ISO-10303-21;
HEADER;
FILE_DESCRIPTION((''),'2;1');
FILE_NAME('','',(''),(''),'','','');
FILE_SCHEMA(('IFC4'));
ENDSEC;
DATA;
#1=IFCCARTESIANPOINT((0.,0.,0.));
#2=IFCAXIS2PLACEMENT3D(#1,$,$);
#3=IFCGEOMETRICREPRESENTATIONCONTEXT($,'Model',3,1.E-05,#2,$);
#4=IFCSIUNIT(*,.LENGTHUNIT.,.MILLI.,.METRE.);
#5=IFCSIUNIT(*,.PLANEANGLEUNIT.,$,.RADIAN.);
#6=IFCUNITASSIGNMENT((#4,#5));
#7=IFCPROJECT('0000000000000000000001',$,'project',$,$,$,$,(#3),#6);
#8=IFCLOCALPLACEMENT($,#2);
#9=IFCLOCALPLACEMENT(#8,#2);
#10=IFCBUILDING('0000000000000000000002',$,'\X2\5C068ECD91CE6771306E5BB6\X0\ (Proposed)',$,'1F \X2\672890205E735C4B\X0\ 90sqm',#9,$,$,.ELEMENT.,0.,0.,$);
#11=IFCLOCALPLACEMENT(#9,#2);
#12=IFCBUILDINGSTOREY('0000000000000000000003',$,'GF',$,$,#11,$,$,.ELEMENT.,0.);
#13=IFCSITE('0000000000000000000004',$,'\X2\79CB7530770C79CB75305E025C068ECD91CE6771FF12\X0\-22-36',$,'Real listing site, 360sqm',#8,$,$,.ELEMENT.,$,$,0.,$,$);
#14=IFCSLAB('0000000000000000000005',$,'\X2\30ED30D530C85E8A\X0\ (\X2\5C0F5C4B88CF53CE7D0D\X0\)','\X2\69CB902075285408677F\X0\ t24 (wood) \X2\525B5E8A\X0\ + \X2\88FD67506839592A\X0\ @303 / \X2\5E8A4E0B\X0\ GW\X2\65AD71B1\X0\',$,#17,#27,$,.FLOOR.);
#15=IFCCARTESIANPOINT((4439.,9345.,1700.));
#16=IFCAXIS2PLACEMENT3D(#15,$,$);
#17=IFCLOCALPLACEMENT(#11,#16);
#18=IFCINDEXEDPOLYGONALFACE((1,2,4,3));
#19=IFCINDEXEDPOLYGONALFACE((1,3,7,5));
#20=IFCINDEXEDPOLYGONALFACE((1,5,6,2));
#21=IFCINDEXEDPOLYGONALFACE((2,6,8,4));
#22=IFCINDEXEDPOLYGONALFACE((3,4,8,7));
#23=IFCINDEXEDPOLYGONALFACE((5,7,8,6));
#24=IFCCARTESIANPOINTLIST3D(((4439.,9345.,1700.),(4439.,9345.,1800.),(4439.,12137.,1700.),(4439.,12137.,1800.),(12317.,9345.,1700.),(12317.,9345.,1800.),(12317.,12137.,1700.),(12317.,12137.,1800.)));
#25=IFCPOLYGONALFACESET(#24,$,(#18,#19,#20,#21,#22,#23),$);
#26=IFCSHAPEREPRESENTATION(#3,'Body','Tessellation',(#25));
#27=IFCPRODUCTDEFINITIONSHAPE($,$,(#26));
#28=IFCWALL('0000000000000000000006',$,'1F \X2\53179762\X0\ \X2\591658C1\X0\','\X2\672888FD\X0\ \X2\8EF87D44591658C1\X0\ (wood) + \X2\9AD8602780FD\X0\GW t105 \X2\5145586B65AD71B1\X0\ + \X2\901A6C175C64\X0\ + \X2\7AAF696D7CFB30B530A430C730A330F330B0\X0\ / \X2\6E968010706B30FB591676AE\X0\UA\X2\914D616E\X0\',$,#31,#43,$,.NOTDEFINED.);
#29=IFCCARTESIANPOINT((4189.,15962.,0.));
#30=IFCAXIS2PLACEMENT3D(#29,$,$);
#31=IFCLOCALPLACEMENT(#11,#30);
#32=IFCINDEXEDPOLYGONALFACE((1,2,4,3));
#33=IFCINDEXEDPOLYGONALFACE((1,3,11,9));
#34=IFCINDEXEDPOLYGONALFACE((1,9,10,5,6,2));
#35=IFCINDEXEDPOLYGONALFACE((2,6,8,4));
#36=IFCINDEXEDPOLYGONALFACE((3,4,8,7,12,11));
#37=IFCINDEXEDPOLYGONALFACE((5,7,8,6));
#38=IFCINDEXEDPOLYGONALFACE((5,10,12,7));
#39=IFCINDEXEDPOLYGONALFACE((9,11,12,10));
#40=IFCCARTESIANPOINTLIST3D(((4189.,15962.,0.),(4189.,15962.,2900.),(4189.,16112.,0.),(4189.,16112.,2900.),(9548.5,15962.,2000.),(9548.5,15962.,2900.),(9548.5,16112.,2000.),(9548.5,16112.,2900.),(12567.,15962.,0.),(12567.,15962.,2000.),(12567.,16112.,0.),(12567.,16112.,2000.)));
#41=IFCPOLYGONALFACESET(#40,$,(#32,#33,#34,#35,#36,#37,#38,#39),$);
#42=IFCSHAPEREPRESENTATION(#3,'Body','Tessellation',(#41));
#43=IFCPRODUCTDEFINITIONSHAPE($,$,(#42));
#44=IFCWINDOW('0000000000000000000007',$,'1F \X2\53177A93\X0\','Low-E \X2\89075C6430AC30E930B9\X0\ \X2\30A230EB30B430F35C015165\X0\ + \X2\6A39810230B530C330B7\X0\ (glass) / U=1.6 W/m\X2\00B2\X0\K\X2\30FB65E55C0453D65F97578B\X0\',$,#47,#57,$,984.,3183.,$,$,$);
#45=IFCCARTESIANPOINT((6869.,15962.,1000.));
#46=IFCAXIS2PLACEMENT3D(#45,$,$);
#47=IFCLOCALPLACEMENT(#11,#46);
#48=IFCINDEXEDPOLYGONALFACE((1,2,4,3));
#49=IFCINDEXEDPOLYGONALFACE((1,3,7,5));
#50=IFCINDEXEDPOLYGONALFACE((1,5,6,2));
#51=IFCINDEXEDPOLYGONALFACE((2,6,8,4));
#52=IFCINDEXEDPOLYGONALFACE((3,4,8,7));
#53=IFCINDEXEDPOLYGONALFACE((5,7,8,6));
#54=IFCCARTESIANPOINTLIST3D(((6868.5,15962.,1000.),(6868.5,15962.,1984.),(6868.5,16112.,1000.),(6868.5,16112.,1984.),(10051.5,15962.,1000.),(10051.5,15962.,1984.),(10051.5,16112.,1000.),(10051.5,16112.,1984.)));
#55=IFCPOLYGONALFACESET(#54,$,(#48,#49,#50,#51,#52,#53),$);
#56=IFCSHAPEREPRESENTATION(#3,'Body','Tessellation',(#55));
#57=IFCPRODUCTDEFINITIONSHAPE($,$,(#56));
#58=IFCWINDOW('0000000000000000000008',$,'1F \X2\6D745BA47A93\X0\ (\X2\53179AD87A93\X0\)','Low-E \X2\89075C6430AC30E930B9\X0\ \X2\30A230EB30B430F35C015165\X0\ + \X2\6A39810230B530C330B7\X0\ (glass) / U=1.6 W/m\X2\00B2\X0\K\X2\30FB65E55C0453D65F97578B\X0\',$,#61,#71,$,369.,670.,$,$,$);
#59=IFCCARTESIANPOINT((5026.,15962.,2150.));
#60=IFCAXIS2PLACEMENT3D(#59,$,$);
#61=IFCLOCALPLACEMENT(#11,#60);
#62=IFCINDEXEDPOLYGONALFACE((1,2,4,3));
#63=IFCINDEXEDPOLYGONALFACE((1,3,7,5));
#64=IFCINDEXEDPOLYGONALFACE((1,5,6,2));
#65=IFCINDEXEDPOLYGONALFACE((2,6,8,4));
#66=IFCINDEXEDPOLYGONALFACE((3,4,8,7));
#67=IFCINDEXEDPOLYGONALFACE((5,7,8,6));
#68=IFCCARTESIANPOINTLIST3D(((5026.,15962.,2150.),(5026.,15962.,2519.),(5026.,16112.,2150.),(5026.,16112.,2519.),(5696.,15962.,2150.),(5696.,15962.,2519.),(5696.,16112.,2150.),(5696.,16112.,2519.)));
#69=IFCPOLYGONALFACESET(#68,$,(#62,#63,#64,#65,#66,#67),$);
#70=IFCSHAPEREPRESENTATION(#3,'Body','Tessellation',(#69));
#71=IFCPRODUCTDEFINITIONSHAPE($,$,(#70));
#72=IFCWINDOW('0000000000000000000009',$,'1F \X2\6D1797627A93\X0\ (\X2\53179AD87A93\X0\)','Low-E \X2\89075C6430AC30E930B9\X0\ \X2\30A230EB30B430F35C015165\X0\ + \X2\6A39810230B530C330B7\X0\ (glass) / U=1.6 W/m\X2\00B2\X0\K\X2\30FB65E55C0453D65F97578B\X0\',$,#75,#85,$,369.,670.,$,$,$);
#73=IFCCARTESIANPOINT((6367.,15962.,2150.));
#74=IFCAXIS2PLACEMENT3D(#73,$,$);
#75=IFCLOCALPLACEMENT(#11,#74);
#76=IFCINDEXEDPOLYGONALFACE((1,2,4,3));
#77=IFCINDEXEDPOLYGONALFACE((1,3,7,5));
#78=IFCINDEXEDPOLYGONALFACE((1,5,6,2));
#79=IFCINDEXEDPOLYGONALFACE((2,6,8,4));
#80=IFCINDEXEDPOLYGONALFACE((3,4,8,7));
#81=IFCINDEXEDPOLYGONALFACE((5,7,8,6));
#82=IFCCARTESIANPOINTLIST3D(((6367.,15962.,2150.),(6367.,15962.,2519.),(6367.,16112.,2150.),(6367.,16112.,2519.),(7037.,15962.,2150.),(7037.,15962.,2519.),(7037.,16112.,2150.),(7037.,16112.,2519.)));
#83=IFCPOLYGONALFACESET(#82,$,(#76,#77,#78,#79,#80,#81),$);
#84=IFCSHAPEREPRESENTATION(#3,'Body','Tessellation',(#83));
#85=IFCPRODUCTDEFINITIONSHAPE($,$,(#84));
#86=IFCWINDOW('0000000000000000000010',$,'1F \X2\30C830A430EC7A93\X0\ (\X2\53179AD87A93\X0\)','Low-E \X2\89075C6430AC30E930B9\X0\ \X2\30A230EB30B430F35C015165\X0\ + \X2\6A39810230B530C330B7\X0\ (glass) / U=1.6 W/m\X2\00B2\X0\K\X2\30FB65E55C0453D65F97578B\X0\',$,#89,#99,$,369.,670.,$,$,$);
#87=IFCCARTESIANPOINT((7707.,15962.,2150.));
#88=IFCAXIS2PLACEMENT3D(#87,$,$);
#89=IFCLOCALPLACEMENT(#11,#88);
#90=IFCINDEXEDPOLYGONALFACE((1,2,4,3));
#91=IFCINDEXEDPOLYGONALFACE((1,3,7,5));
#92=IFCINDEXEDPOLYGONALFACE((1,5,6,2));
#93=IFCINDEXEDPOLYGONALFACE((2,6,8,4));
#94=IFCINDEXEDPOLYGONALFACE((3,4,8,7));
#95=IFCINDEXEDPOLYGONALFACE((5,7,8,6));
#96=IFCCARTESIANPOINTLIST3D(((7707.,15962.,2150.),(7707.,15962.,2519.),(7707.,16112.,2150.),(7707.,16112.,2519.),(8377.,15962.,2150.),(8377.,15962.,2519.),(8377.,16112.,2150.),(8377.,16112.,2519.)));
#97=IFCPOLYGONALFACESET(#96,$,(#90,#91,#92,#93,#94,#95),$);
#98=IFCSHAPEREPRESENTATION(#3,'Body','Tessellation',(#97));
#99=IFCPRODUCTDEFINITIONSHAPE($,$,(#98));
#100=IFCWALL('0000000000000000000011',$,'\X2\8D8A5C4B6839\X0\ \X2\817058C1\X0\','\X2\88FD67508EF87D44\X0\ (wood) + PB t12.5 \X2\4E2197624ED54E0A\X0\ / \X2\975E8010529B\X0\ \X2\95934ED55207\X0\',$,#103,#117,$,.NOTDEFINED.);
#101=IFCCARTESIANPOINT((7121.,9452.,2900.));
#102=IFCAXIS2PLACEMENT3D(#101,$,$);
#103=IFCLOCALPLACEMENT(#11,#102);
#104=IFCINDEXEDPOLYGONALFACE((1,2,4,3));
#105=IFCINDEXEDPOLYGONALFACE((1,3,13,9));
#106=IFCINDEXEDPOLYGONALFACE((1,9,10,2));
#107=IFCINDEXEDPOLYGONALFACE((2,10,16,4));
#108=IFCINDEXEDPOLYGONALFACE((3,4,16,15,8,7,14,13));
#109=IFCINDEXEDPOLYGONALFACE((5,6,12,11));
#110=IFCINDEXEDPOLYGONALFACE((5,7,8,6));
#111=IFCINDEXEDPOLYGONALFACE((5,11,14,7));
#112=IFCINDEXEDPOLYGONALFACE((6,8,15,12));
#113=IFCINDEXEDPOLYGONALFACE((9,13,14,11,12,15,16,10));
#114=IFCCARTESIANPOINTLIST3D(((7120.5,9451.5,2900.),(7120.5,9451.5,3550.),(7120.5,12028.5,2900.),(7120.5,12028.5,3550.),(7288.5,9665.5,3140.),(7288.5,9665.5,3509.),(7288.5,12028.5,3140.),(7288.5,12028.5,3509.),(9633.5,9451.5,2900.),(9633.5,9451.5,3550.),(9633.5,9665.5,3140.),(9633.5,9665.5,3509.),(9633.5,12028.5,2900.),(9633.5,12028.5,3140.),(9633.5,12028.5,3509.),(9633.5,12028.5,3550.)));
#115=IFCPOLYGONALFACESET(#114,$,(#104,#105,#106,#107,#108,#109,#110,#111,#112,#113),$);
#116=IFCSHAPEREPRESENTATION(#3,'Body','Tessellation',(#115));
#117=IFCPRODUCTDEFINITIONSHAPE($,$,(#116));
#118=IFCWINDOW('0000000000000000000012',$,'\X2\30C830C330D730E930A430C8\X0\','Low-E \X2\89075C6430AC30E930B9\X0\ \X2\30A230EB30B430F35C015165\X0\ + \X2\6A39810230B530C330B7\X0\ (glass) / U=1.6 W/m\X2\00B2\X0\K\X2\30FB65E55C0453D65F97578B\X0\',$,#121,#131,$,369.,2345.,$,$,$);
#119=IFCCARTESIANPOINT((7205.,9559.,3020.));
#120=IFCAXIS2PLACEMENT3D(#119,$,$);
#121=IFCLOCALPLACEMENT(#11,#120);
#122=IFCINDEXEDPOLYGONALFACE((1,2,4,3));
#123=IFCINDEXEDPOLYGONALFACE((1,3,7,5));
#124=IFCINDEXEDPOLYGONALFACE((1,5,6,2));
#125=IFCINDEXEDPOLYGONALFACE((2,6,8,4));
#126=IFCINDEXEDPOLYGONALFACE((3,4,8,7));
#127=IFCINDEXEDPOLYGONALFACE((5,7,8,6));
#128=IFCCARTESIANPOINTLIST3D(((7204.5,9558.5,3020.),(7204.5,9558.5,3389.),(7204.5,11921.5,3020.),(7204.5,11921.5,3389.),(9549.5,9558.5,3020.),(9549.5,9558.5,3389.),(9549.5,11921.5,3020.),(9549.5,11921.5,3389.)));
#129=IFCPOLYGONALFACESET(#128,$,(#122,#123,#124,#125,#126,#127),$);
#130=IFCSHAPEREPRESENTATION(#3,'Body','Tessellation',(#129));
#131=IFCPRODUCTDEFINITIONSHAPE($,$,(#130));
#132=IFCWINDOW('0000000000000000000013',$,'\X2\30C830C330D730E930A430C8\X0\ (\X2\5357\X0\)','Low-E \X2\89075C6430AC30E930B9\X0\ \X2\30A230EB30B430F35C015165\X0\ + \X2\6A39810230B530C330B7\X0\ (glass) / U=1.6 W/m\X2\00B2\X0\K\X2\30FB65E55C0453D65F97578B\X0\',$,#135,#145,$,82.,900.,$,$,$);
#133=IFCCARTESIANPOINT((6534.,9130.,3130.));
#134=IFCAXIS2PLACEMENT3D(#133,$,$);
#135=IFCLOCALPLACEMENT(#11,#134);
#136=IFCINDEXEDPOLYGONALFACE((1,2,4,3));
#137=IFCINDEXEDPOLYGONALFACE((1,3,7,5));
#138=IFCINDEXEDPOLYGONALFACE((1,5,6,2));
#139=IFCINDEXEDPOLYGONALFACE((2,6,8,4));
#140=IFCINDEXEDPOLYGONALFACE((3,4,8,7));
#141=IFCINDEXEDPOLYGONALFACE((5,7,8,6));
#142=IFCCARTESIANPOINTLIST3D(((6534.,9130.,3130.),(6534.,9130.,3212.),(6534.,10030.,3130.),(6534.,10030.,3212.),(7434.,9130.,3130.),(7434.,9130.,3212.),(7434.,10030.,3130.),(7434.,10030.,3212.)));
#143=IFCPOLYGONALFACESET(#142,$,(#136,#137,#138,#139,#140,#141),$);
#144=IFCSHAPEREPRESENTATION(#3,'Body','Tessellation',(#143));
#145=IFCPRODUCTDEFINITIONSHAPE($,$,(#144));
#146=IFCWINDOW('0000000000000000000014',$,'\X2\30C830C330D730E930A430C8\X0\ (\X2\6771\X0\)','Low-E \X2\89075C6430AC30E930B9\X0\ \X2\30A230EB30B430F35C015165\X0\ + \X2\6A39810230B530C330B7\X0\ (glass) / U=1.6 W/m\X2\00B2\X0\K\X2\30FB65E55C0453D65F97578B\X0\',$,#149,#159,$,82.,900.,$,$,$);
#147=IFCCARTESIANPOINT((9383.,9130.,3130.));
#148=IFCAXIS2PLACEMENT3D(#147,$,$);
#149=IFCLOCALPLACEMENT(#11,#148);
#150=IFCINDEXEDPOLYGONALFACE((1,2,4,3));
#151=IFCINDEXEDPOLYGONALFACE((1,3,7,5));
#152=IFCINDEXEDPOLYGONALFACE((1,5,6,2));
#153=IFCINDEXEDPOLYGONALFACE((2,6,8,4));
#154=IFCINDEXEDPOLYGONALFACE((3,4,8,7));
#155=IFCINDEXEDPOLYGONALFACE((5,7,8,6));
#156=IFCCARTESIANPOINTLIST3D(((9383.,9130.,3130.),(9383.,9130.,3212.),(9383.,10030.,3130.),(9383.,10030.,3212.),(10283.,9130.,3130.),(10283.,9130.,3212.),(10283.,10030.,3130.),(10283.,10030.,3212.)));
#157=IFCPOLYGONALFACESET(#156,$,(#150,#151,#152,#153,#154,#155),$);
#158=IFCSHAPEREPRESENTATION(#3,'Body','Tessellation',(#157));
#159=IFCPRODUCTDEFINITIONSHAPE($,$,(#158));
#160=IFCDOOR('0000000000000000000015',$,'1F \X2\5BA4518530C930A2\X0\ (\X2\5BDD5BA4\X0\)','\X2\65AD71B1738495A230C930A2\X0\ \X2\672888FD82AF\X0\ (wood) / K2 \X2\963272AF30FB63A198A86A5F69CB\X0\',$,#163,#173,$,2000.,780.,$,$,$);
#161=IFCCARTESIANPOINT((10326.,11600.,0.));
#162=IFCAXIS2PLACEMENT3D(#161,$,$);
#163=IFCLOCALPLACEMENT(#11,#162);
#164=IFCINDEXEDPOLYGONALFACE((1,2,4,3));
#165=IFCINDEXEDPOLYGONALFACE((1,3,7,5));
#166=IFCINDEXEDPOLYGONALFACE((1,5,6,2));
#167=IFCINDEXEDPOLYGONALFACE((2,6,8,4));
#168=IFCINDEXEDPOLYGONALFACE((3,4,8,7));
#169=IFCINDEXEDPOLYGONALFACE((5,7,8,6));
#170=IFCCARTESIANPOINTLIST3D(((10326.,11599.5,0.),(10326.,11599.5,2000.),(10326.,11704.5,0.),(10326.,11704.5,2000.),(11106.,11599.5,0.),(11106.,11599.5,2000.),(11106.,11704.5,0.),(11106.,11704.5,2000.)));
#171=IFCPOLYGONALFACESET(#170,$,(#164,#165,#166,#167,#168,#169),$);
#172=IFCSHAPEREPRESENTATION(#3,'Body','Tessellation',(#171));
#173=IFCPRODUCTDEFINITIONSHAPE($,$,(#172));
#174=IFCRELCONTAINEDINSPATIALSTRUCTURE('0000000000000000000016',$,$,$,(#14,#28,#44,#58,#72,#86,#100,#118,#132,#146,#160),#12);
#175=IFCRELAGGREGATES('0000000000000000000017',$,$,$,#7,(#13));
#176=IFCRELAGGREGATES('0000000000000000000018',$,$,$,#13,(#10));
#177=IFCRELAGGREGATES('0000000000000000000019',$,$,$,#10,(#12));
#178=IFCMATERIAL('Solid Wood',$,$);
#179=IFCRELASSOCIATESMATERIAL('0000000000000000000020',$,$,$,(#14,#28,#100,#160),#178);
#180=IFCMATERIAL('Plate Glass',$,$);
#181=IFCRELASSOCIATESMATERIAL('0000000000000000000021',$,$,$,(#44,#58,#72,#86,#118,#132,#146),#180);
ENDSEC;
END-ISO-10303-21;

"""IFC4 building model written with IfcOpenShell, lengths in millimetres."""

from ifc_helpers import new_model, si_unit, frame, frame_2d, origin, place, context, project, spatial, rectangle, extrude, material, element, fill, save


model = new_model("IFC4")

# Units and contexts
model_context = context("Model", 3, precision=1e-05, world=origin())
ifc_project = project(units=[si_unit("LENGTHUNIT", "METRE", prefix="MILLI"), si_unit("PLANEANGLEUNIT", "RADIAN")], contexts=[model_context])

# Site, building, storey
site_placement = place(None, origin())
site = spatial("IfcSite", under=ifc_project, at=site_placement, Name="秋田県秋田市将軍野東２-22-36", ObjectType="Real listing site, 360sqm", CompositionType="ELEMENT", RefElevation=0.0)
building_placement = place(site_placement, origin())
building = spatial("IfcBuilding", under=site, at=building_placement, Name="将軍野東の家 (Proposed)", ObjectType="1F 木造平屋 90sqm", CompositionType="ELEMENT", ElevationOfRefHeight=0.0, ElevationOfTerrain=0.0)
storey_placement = place(building_placement, origin())
storey = spatial("IfcBuildingStorey", under=building, at=storey_placement, Name="GF", CompositionType="ELEMENT", Elevation=0.0)

# Slab
ifc_material_1 = material(Name="Solid Wood")
slab_placement = place(storey_placement, frame((4439.0, 9345.0, 1700.0)))
element("IfcSlab", 1, at=slab_placement, inside=storey, material=ifc_material_1, Name="ロフト床 (小屋裏収納)", Description="構造用合板 t24 (wood) 剛床 + 製材根太 @303 / 床下 GW断熱", PredefinedType="FLOOR", context=model_context, shape_type="SweptSolid", body=[
    extrude(rectangle(XDim=7878.0, YDim=2792.0, at=frame_2d((3939.0, 1396.0))), frame((4439.0, 9345.0, 1700.0)), (0.0, 0.0, 1.0), 100.0),
])

# Wall, openings, windows
wall_1_placement = place(storey_placement, frame((4189.0, 15962.0, 0.0)))
wall_1 = element("IfcWall", 2, at=wall_1_placement, inside=storey, material=ifc_material_1, Name="1F 北面 外壁", Description="木製 軸組外壁 (wood) + 高性能GW t105 充填断熱 + 通気層 + 窯業系サイディング / 準耐火・外皮UA配慮", PredefinedType="NOTDEFINED", context=model_context, shape_type="SweptSolid", body=[
    extrude(rectangle(XDim=8378.0, YDim=150.0, at=frame_2d((4189.0, 75.0))), frame((4189.0, 15962.0, 0.0)), (0.0, 0.0, 1.0), 2900.0),
])
opening_1_placement = place(storey_placement, frame((6869.0, 15962.0, 1000.0)))
opening_1 = element("IfcOpeningElement", 3, at=opening_1_placement, cuts=wall_1, PredefinedType="NOTDEFINED", context=model_context, shape_type="SweptSolid", body=[
    extrude(rectangle(XDim=3183.0, YDim=150.0, at=frame_2d((1591.0, 75.0))), frame((6869.0, 15962.0, 1000.0)), (0.0, 0.0, 1.0), 984.0),
])
opening_2_placement = place(storey_placement, frame((5026.0, 15962.0, 2150.0)))
opening_2 = element("IfcOpeningElement", 4, at=opening_2_placement, cuts=wall_1, PredefinedType="NOTDEFINED", context=model_context, shape_type="SweptSolid", body=[
    extrude(rectangle(XDim=670.0, YDim=150.0, at=frame_2d((335.0, 75.0))), frame((5026.0, 15962.0, 2150.0)), (0.0, 0.0, 1.0), 369.0),
])
opening_3_placement = place(storey_placement, frame((6367.0, 15962.0, 2150.0)))
opening_3 = element("IfcOpeningElement", 5, at=opening_3_placement, cuts=wall_1, PredefinedType="NOTDEFINED", context=model_context, shape_type="SweptSolid", body=[
    extrude(rectangle(XDim=670.0, YDim=150.0, at=frame_2d((335.0, 75.0))), frame((6367.0, 15962.0, 2150.0)), (0.0, 0.0, 1.0), 369.0),
])
opening_4_placement = place(storey_placement, frame((7707.0, 15962.0, 2150.0)))
opening_4 = element("IfcOpeningElement", 6, at=opening_4_placement, cuts=wall_1, PredefinedType="NOTDEFINED", context=model_context, shape_type="SweptSolid", body=[
    extrude(rectangle(XDim=670.0, YDim=150.0, at=frame_2d((335.0, 75.0))), frame((7707.0, 15962.0, 2150.0)), (0.0, 0.0, 1.0), 369.0),
])
ifc_material_2 = material(Name="Plate Glass")
window_1_placement = place(storey_placement, frame((6869.0, 15962.0, 1000.0)))
window_1 = element("IfcWindow", 7, at=window_1_placement, inside=storey, material=ifc_material_2, Name="1F 北窓", Description="Low-E 複層ガラス アルゴン封入 + 樹脂サッシ (glass) / U=1.6 W/m²K・日射取得型", OverallHeight=984.0, OverallWidth=3183.0, context=model_context, shape_type="SweptSolid", body=[
    extrude(rectangle(XDim=3183.0, YDim=150.0, at=frame_2d((1591.0, 75.0))), frame((6869.0, 15962.0, 1000.0)), (0.0, 0.0, 1.0), 984.0),
])
fill(opening_1, window_1)
window_2_placement = place(storey_placement, frame((5026.0, 15962.0, 2150.0)))
window_2 = element("IfcWindow", 8, at=window_2_placement, inside=storey, material=ifc_material_2, Name="1F 浴室窓 (北高窓)", Description="Low-E 複層ガラス アルゴン封入 + 樹脂サッシ (glass) / U=1.6 W/m²K・日射取得型", OverallHeight=369.0, OverallWidth=670.0, context=model_context, shape_type="SweptSolid", body=[
    extrude(rectangle(XDim=670.0, YDim=150.0, at=frame_2d((335.0, 75.0))), frame((5026.0, 15962.0, 2150.0)), (0.0, 0.0, 1.0), 369.0),
])
fill(opening_2, window_2)
window_3_placement = place(storey_placement, frame((6367.0, 15962.0, 2150.0)))
window_3 = element("IfcWindow", 9, at=window_3_placement, inside=storey, material=ifc_material_2, Name="1F 洗面窓 (北高窓)", Description="Low-E 複層ガラス アルゴン封入 + 樹脂サッシ (glass) / U=1.6 W/m²K・日射取得型", OverallHeight=369.0, OverallWidth=670.0, context=model_context, shape_type="SweptSolid", body=[
    extrude(rectangle(XDim=670.0, YDim=150.0, at=frame_2d((335.0, 75.0))), frame((6367.0, 15962.0, 2150.0)), (0.0, 0.0, 1.0), 369.0),
])
fill(opening_3, window_3)
window_4_placement = place(storey_placement, frame((7707.0, 15962.0, 2150.0)))
window_4 = element("IfcWindow", 10, at=window_4_placement, inside=storey, material=ifc_material_2, Name="1F トイレ窓 (北高窓)", Description="Low-E 複層ガラス アルゴン封入 + 樹脂サッシ (glass) / U=1.6 W/m²K・日射取得型", OverallHeight=369.0, OverallWidth=670.0, context=model_context, shape_type="SweptSolid", body=[
    extrude(rectangle(XDim=670.0, YDim=150.0, at=frame_2d((335.0, 75.0))), frame((7707.0, 15962.0, 2150.0)), (0.0, 0.0, 1.0), 369.0),
])
fill(opening_4, window_4)

# Wall, openings, windows
wall_2_placement = place(storey_placement, frame((7121.0, 9452.0, 2900.0)))
wall_2 = element("IfcWall", 11, at=wall_2_placement, inside=storey, material=ifc_material_1, Name="越屋根 腰壁", Description="製材軸組 (wood) + PB t12.5 両面仕上 / 非耐力 間仕切", PredefinedType="NOTDEFINED", context=model_context, shape_type="SweptSolid", body=[
    extrude(rectangle(XDim=2513.0, YDim=2577.0, at=frame_2d((1256.0, 1288.0))), frame((7121.0, 9452.0, 2900.0)), (0.0, 0.0, 1.0), 650.0),
])
opening_5_placement = place(storey_placement, frame((7205.0, 9559.0, 3020.0)))
opening_5 = element("IfcOpeningElement", 12, at=opening_5_placement, cuts=wall_2, PredefinedType="NOTDEFINED", context=model_context, shape_type="SweptSolid", body=[
    extrude(rectangle(XDim=2345.0, YDim=2363.0, at=frame_2d((1172.0, 1181.0))), frame((7205.0, 9559.0, 3020.0)), (0.0, 0.0, 1.0), 369.0),
])
opening_6_placement = place(storey_placement, frame((6534.0, 9130.0, 3130.0)))
opening_6 = element("IfcOpeningElement", 13, at=opening_6_placement, cuts=wall_2, PredefinedType="NOTDEFINED", context=model_context, shape_type="SweptSolid", body=[
    extrude(rectangle(XDim=900.0, YDim=900.0, at=frame_2d((450.0, 450.0))), frame((6534.0, 9130.0, 3130.0)), (0.0, 0.0, 1.0), 82.0),
])
opening_7_placement = place(storey_placement, frame((9383.0, 9130.0, 3130.0)))
opening_7 = element("IfcOpeningElement", 14, at=opening_7_placement, cuts=wall_2, PredefinedType="NOTDEFINED", context=model_context, shape_type="SweptSolid", body=[
    extrude(rectangle(XDim=900.0, YDim=900.0, at=frame_2d((450.0, 450.0))), frame((9383.0, 9130.0, 3130.0)), (0.0, 0.0, 1.0), 82.0),
])
window_5_placement = place(storey_placement, frame((7205.0, 9559.0, 3020.0)))
window_5 = element("IfcWindow", 15, at=window_5_placement, inside=storey, material=ifc_material_2, Name="トップライト", Description="Low-E 複層ガラス アルゴン封入 + 樹脂サッシ (glass) / U=1.6 W/m²K・日射取得型", OverallHeight=369.0, OverallWidth=2345.0, context=model_context, shape_type="SweptSolid", body=[
    extrude(rectangle(XDim=2345.0, YDim=2363.0, at=frame_2d((1172.0, 1181.0))), frame((7205.0, 9559.0, 3020.0)), (0.0, 0.0, 1.0), 369.0),
])
fill(opening_5, window_5)
window_6_placement = place(storey_placement, frame((6534.0, 9130.0, 3130.0)))
window_6 = element("IfcWindow", 16, at=window_6_placement, inside=storey, material=ifc_material_2, Name="トップライト (南)", Description="Low-E 複層ガラス アルゴン封入 + 樹脂サッシ (glass) / U=1.6 W/m²K・日射取得型", OverallHeight=82.0, OverallWidth=900.0, context=model_context, shape_type="SweptSolid", body=[
    extrude(rectangle(XDim=900.0, YDim=900.0, at=frame_2d((450.0, 450.0))), frame((6534.0, 9130.0, 3130.0)), (0.0, 0.0, 1.0), 82.0),
])
fill(opening_6, window_6)
window_7_placement = place(storey_placement, frame((9383.0, 9130.0, 3130.0)))
window_7 = element("IfcWindow", 17, at=window_7_placement, inside=storey, material=ifc_material_2, Name="トップライト (東)", Description="Low-E 複層ガラス アルゴン封入 + 樹脂サッシ (glass) / U=1.6 W/m²K・日射取得型", OverallHeight=82.0, OverallWidth=900.0, context=model_context, shape_type="SweptSolid", body=[
    extrude(rectangle(XDim=900.0, YDim=900.0, at=frame_2d((450.0, 450.0))), frame((9383.0, 9130.0, 3130.0)), (0.0, 0.0, 1.0), 82.0),
])
fill(opening_7, window_7)

# Door
door_1_placement = place(storey_placement, frame((10326.0, 11600.0, 0.0)))
element("IfcDoor", 18, at=door_1_placement, inside=storey, material=ifc_material_1, Name="1F 室内ドア (寝室)", Description="断熱玄関ドア 木製芯 (wood) / K2 防犯・採風機構", OverallHeight=2000.0, OverallWidth=780.0, context=model_context, shape_type="SweptSolid", body=[
    extrude(rectangle(XDim=780.0, YDim=105.0, at=frame_2d((390.0, 52.0))), frame((10326.0, 11600.0, 0.0)), (0.0, 0.0, 1.0), 2000.0),
])

save(model, "model.ifc")
